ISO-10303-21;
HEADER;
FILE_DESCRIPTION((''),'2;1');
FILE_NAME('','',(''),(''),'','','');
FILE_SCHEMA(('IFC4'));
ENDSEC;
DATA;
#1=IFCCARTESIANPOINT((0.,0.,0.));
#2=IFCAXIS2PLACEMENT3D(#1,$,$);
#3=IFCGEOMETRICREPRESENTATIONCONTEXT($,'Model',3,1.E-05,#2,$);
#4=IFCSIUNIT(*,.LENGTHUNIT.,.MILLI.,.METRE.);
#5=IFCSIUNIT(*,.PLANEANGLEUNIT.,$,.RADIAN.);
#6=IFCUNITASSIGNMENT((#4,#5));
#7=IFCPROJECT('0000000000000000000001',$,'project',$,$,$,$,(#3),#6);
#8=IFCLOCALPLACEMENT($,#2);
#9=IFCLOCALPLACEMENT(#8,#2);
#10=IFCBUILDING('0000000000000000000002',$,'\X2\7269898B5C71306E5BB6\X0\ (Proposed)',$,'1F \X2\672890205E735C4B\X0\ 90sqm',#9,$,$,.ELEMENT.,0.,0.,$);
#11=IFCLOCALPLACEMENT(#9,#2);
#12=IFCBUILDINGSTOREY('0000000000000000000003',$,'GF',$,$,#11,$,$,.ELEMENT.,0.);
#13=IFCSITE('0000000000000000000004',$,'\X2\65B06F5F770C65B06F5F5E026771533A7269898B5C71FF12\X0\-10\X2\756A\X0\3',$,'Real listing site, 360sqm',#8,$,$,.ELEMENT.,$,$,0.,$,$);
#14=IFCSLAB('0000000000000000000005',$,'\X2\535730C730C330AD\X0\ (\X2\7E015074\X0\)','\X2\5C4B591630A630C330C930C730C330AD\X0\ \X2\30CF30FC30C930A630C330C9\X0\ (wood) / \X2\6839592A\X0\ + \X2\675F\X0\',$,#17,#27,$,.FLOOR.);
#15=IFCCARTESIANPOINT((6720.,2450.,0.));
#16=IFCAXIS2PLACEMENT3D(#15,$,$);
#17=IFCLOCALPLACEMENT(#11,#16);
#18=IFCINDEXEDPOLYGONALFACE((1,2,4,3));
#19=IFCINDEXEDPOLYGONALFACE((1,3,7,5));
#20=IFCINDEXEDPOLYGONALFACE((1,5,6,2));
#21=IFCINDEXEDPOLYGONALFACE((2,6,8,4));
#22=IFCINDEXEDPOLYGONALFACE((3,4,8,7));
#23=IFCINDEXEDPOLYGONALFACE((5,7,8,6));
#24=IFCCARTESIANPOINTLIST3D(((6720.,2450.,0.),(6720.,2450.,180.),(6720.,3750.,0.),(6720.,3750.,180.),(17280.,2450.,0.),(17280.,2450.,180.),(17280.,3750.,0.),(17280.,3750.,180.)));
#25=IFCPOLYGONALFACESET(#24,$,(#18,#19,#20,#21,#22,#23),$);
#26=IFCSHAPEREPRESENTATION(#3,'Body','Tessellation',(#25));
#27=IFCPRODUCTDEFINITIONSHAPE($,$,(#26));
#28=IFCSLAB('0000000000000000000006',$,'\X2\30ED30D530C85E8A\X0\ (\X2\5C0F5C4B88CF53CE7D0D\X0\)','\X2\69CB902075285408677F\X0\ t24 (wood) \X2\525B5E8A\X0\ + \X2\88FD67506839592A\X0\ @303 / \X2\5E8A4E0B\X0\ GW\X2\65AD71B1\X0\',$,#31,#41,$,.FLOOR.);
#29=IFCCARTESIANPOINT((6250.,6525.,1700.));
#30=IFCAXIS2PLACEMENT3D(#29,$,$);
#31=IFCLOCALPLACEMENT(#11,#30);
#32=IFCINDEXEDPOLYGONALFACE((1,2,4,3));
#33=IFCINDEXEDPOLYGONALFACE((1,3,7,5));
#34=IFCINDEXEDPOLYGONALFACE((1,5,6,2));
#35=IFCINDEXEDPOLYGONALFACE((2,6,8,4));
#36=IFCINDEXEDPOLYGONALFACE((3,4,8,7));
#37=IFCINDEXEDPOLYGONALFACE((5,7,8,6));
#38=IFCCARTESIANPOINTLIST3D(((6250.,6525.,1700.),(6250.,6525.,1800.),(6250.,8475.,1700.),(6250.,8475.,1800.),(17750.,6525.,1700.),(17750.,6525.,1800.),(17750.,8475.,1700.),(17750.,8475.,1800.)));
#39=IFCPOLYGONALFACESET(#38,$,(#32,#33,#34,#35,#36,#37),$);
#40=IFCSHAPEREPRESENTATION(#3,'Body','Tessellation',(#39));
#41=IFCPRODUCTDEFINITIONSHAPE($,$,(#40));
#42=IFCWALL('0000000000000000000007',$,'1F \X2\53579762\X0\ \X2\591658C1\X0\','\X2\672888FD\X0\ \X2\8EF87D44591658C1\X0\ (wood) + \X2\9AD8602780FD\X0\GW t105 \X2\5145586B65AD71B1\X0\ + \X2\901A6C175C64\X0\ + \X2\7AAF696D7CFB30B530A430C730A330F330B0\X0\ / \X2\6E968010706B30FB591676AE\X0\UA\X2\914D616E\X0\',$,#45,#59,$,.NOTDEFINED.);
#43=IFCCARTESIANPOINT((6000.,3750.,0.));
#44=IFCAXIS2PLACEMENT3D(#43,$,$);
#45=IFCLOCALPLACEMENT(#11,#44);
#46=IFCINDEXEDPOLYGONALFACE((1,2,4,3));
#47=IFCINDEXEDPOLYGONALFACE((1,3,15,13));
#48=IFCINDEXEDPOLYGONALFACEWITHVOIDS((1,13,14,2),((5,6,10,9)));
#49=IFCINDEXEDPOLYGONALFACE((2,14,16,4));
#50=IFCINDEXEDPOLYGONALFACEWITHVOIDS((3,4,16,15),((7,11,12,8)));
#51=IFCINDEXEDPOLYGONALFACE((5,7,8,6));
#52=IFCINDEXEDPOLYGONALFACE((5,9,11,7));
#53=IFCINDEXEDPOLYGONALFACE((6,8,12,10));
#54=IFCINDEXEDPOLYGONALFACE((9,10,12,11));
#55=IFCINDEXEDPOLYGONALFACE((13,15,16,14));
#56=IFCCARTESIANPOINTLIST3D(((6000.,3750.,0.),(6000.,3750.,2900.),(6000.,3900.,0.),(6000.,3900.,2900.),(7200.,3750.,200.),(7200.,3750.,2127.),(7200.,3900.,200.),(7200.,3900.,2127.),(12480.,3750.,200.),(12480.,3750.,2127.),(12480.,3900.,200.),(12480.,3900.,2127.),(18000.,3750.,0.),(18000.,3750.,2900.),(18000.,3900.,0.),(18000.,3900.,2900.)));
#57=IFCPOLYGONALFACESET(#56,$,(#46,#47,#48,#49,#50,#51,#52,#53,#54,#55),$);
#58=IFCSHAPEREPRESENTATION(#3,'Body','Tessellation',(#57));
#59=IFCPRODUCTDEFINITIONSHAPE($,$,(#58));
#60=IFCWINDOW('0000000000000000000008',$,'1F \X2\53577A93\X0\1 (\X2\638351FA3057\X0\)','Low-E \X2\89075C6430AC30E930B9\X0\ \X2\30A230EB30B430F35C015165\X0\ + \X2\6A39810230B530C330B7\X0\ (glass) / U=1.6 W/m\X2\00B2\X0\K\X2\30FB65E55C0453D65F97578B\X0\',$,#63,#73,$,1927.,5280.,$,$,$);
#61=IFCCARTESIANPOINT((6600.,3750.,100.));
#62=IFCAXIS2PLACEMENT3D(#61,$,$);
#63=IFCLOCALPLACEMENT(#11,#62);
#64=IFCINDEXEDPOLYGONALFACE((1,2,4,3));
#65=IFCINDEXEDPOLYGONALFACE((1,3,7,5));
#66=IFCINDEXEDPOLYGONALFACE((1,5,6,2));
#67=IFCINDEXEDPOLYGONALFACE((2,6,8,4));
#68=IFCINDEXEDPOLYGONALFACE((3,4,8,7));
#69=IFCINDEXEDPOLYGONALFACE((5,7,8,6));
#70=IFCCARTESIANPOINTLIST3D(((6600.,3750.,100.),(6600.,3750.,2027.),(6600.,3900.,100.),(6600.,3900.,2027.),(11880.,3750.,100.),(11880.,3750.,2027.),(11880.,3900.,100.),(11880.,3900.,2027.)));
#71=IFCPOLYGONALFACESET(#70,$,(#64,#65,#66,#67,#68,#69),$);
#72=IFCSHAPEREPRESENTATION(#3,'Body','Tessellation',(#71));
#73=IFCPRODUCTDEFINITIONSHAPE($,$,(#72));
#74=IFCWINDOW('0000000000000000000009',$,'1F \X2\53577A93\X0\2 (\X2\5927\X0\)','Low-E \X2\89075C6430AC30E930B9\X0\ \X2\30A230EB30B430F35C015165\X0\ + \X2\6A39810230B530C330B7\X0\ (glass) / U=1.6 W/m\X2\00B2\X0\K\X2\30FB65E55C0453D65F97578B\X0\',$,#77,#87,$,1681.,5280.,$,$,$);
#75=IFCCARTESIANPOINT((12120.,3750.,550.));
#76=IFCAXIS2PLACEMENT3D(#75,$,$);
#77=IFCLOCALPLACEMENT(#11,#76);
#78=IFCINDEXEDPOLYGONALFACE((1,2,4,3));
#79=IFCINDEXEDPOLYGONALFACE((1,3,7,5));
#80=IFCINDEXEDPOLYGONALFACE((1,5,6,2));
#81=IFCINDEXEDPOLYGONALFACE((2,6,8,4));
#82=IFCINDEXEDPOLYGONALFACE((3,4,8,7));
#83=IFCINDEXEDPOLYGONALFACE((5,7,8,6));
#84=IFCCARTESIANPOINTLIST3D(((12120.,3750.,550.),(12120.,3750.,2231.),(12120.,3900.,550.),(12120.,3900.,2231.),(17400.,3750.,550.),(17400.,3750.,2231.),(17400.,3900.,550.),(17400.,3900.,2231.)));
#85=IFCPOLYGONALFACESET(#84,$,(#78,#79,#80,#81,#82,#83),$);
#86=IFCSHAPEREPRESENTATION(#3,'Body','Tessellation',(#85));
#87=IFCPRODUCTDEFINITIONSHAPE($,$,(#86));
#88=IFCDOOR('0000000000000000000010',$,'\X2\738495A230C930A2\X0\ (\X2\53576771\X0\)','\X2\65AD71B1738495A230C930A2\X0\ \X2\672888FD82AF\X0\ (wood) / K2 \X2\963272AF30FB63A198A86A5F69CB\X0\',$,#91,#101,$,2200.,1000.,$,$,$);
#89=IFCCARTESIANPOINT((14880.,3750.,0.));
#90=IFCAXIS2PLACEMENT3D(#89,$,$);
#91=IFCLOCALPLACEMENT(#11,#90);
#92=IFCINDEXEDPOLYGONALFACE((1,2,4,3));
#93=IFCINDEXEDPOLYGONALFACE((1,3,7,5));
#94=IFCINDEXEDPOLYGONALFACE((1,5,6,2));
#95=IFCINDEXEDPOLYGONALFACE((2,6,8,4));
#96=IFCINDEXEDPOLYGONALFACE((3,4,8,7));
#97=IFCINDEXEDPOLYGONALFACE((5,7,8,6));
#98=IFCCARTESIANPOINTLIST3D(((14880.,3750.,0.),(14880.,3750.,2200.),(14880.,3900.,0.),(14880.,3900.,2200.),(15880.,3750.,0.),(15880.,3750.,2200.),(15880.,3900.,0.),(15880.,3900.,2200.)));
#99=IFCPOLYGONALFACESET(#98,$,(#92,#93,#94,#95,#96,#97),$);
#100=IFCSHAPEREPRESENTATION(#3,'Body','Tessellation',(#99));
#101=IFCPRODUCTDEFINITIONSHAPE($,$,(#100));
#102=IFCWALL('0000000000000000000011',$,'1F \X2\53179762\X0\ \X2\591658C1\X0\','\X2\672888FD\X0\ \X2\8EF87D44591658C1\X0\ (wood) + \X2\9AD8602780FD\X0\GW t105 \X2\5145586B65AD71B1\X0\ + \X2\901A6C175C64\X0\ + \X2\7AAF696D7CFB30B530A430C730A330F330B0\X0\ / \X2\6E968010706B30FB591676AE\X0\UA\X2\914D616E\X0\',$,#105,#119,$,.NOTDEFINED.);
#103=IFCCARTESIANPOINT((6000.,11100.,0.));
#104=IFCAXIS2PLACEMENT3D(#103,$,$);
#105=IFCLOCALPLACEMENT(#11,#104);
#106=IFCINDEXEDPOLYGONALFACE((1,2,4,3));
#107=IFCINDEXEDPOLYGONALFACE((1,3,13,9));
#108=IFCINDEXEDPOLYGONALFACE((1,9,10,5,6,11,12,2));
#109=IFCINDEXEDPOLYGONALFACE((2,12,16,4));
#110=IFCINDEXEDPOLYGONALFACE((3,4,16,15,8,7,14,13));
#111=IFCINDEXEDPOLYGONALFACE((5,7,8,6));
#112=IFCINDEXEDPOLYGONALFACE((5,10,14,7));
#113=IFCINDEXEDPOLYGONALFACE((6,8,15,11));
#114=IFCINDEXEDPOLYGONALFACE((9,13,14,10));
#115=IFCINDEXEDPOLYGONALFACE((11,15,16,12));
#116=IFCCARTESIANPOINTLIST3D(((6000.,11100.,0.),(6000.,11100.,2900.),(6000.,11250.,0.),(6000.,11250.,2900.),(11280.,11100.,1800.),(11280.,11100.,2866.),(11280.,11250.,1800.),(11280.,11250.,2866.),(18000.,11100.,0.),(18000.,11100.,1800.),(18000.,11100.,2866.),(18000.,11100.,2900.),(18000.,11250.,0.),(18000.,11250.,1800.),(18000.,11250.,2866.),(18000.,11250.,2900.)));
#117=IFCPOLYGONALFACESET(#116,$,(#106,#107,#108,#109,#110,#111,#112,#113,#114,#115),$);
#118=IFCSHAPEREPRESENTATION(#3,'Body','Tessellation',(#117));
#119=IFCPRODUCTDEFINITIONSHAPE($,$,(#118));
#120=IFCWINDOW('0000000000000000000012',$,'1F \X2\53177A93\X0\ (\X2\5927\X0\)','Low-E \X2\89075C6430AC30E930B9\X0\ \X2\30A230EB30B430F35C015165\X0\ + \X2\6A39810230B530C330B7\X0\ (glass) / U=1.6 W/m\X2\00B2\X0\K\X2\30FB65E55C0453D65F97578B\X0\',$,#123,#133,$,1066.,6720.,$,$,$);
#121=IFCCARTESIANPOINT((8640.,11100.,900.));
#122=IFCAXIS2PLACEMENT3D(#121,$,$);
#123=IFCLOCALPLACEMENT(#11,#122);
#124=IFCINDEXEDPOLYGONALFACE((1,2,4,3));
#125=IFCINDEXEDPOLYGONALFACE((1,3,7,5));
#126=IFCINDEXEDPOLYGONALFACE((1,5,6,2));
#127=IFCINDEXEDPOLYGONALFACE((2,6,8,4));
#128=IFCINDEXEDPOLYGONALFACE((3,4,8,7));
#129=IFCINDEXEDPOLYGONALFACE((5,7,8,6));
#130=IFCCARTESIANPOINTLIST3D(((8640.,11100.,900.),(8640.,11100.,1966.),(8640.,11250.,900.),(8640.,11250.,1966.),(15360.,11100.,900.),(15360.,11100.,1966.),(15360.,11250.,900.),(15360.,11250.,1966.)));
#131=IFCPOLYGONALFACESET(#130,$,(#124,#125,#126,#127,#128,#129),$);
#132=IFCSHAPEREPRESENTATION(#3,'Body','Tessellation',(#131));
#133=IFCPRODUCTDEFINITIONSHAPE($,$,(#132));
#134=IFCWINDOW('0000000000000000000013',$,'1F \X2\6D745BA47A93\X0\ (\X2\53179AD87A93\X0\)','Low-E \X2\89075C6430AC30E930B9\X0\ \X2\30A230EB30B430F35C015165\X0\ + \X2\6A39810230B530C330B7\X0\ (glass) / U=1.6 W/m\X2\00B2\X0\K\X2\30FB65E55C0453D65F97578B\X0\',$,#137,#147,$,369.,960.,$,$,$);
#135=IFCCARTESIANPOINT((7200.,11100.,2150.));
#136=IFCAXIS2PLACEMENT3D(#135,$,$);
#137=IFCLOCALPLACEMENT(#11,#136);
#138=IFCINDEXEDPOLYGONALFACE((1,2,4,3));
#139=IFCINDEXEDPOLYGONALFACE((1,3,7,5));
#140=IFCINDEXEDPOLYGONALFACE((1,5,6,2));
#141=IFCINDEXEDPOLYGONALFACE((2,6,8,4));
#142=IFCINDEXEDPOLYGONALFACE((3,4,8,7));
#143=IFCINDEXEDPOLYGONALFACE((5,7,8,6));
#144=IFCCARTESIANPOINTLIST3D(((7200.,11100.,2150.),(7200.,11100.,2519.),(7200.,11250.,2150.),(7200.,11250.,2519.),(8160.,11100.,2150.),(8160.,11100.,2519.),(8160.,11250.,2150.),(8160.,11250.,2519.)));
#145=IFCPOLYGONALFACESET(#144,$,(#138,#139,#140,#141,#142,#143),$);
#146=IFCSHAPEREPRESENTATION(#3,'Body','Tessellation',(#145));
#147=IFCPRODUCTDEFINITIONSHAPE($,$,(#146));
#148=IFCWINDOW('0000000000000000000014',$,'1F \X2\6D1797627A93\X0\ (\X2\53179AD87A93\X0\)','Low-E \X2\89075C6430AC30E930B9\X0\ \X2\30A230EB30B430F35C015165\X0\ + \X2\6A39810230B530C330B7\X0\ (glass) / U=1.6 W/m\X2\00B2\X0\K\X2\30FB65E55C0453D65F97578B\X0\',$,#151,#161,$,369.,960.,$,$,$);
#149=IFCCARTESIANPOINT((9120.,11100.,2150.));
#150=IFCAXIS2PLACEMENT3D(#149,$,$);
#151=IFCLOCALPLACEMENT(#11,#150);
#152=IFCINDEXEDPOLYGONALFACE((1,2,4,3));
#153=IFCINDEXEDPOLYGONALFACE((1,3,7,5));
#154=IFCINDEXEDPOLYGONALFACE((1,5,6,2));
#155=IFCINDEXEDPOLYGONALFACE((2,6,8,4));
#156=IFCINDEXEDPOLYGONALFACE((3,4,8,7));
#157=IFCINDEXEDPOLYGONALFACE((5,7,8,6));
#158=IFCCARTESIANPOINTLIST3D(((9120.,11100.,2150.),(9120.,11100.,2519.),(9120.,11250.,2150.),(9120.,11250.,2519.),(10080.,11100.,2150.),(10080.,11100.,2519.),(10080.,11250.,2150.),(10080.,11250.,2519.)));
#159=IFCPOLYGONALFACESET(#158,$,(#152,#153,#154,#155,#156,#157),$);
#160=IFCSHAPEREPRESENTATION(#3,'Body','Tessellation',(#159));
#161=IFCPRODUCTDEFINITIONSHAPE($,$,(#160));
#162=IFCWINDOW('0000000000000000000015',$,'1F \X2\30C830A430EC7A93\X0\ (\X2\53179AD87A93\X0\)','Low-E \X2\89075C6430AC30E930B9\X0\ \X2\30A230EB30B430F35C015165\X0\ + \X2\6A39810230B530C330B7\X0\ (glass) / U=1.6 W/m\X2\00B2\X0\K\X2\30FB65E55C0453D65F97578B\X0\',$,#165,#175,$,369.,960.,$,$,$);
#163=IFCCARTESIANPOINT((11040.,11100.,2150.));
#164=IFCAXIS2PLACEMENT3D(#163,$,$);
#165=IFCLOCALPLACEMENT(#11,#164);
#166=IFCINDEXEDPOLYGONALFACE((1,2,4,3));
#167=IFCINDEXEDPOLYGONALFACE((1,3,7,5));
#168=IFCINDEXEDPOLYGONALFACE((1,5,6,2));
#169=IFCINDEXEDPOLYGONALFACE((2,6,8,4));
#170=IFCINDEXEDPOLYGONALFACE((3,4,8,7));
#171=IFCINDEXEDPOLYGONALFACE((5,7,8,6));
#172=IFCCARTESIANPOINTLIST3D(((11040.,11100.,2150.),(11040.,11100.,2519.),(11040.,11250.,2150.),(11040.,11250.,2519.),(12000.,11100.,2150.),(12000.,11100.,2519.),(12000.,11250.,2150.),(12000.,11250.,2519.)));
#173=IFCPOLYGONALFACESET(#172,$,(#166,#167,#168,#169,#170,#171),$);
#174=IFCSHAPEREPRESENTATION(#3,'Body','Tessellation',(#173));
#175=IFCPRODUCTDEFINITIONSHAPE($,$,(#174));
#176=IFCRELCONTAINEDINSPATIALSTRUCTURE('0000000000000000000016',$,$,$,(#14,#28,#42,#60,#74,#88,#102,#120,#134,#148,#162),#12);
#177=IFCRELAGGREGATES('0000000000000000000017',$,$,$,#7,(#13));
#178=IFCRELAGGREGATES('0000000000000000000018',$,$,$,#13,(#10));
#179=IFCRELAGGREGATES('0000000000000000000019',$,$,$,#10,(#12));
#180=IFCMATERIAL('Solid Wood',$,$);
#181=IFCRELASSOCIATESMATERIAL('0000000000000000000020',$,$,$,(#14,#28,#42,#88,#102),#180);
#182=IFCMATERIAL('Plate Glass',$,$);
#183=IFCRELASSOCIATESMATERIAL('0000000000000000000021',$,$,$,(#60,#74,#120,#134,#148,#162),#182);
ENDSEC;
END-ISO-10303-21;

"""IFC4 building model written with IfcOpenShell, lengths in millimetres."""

from ifc_helpers import new_model, si_unit, frame, frame_2d, origin, place, context, project, spatial, rectangle, extrude, material, element, fill, save


model = new_model("IFC4")

# Units and contexts
model_context = context("Model", 3, precision=1e-05, world=origin())
ifc_project = project(units=[si_unit("LENGTHUNIT", "METRE", prefix="MILLI"), si_unit("PLANEANGLEUNIT", "RADIAN")], contexts=[model_context])

# Site, building, storey
site_placement = place(None, origin())
site = spatial("IfcSite", under=ifc_project, at=site_placement, Name="新潟県新潟市東区物見山２-10番3", ObjectType="Real listing site, 360sqm", CompositionType="ELEMENT", RefElevation=0.0)
building_placement = place(site_placement, origin())
building = spatial("IfcBuilding", under=site, at=building_placement, Name="物見山の家 (Proposed)", ObjectType="1F 木造平屋 90sqm", CompositionType="ELEMENT", ElevationOfRefHeight=0.0, ElevationOfTerrain=0.0)
storey_placement = place(building_placement, origin())
storey = spatial("IfcBuildingStorey", under=building, at=storey_placement, Name="GF", CompositionType="ELEMENT", Elevation=0.0)

# Slabs
ifc_material_1 = material(Name="Solid Wood")
slab_1_placement = place(storey_placement, frame((6720.0, 2450.0, 0.0)))
element("IfcSlab", 1, at=slab_1_placement, inside=storey, material=ifc_material_1, Name="南デッキ (縁側)", Description="屋外ウッドデッキ ハードウッド (wood) / 根太 + 束", PredefinedType="FLOOR", context=model_context, shape_type="SweptSolid", body=[
    extrude(rectangle(XDim=10560.0, YDim=1300.0, at=frame_2d((5280.0, 650.0))), frame((6720.0, 2450.0, 0.0)), (0.0, 0.0, 1.0), 180.0),
])
slab_2_placement = place(storey_placement, frame((6250.0, 6525.0, 1700.0)))
element("IfcSlab", 2, at=slab_2_placement, inside=storey, material=ifc_material_1, Name="ロフト床 (小屋裏収納)", Description="構造用合板 t24 (wood) 剛床 + 製材根太 @303 / 床下 GW断熱", PredefinedType="FLOOR", context=model_context, shape_type="SweptSolid", body=[
    extrude(rectangle(XDim=11500.0, YDim=1950.0, at=frame_2d((5750.0, 975.0))), frame((6250.0, 6525.0, 1700.0)), (0.0, 0.0, 1.0), 100.0),
])

# Wall, openings, windows, door
wall_1_placement = place(storey_placement, frame((6000.0, 3750.0, 0.0)))
wall_1 = element("IfcWall", 3, at=wall_1_placement, inside=storey, material=ifc_material_1, Name="1F 南面 外壁", Description="木製 軸組外壁 (wood) + 高性能GW t105 充填断熱 + 通気層 + 窯業系サイディング / 準耐火・外皮UA配慮", PredefinedType="NOTDEFINED", context=model_context, shape_type="SweptSolid", body=[
    extrude(rectangle(XDim=12000.0, YDim=150.0, at=frame_2d((6000.0, 75.0))), frame((6000.0, 3750.0, 0.0)), (0.0, 0.0, 1.0), 2900.0),
])
opening_1_placement = place(storey_placement, frame((6600.0, 3750.0, 100.0)))
opening_1 = element("IfcOpeningElement", 4, at=opening_1_placement, cuts=wall_1, PredefinedType="NOTDEFINED", context=model_context, shape_type="SweptSolid", body=[
    extrude(rectangle(XDim=5280.0, YDim=150.0, at=frame_2d((2640.0, 75.0))), frame((6600.0, 3750.0, 100.0)), (0.0, 0.0, 1.0), 1927.0),
])
opening_2_placement = place(storey_placement, frame((12120.0, 3750.0, 550.0)))
opening_2 = element("IfcOpeningElement", 5, at=opening_2_placement, cuts=wall_1, PredefinedType="NOTDEFINED", context=model_context, shape_type="SweptSolid", body=[
    extrude(rectangle(XDim=5280.0, YDim=150.0, at=frame_2d((2640.0, 75.0))), frame((12120.0, 3750.0, 550.0)), (0.0, 0.0, 1.0), 1681.0),
])
opening_3_placement = place(storey_placement, frame((14880.0, 3750.0, 0.0)))
opening_3 = element("IfcOpeningElement", 6, at=opening_3_placement, cuts=wall_1, PredefinedType="NOTDEFINED", context=model_context, shape_type="SweptSolid", body=[
    extrude(rectangle(XDim=1000.0, YDim=150.0, at=frame_2d((500.0, 75.0))), frame((14880.0, 3750.0, 0.0)), (0.0, 0.0, 1.0), 2200.0),
])
ifc_material_2 = material(Name="Plate Glass")
window_1_placement = place(storey_placement, frame((6600.0, 3750.0, 100.0)))
window_1 = element("IfcWindow", 7, at=window_1_placement, inside=storey, material=ifc_material_2, Name="1F 南窓1 (掃出し)", Description="Low-E 複層ガラス アルゴン封入 + 樹脂サッシ (glass) / U=1.6 W/m²K・日射取得型", OverallHeight=1927.0, OverallWidth=5280.0, context=model_context, shape_type="SweptSolid", body=[
    extrude(rectangle(XDim=5280.0, YDim=150.0, at=frame_2d((2640.0, 75.0))), frame((6600.0, 3750.0, 100.0)), (0.0, 0.0, 1.0), 1927.0),
])
fill(opening_1, window_1)
window_2_placement = place(storey_placement, frame((12120.0, 3750.0, 550.0)))
window_2 = element("IfcWindow", 8, at=window_2_placement, inside=storey, material=ifc_material_2, Name="1F 南窓2 (大)", Description="Low-E 複層ガラス アルゴン封入 + 樹脂サッシ (glass) / U=1.6 W/m²K・日射取得型", OverallHeight=1681.0, OverallWidth=5280.0, context=model_context, shape_type="SweptSolid", body=[
    extrude(rectangle(XDim=5280.0, YDim=150.0, at=frame_2d((2640.0, 75.0))), frame((12120.0, 3750.0, 550.0)), (0.0, 0.0, 1.0), 1681.0),
])
fill(opening_2, window_2)
door_1_placement = place(storey_placement, frame((14880.0, 3750.0, 0.0)))
door_1 = element("IfcDoor", 9, at=door_1_placement, inside=storey, material=ifc_material_1, Name="玄関ドア (南東)", Description="断熱玄関ドア 木製芯 (wood) / K2 防犯・採風機構", OverallHeight=2200.0, OverallWidth=1000.0, context=model_context, shape_type="SweptSolid", body=[
    extrude(rectangle(XDim=1000.0, YDim=150.0, at=frame_2d((500.0, 75.0))), frame((14880.0, 3750.0, 0.0)), (0.0, 0.0, 1.0), 2200.0),
])
fill(opening_3, door_1)

# Wall, openings, windows
wall_2_placement = place(storey_placement, frame((6000.0, 11100.0, 0.0)))
wall_2 = element("IfcWall", 10, at=wall_2_placement, inside=storey, material=ifc_material_1, Name="1F 北面 外壁", Description="木製 軸組外壁 (wood) + 高性能GW t105 充填断熱 + 通気層 + 窯業系サイディング / 準耐火・外皮UA配慮", PredefinedType="NOTDEFINED", context=model_context, shape_type="SweptSolid", body=[
    extrude(rectangle(XDim=12000.0, YDim=150.0, at=frame_2d((6000.0, 75.0))), frame((6000.0, 11100.0, 0.0)), (0.0, 0.0, 1.0), 2900.0),
])
opening_4_placement = place(storey_placement, frame((8640.0, 11100.0, 900.0)))
opening_4 = element("IfcOpeningElement", 11, at=opening_4_placement, cuts=wall_2, PredefinedType="NOTDEFINED", context=model_context, shape_type="SweptSolid", body=[
    extrude(rectangle(XDim=6720.0, YDim=150.0, at=frame_2d((3360.0, 75.0))), frame((8640.0, 11100.0, 900.0)), (0.0, 0.0, 1.0), 1066.0),
])
opening_5_placement = place(storey_placement, frame((7200.0, 11100.0, 2150.0)))
opening_5 = element("IfcOpeningElement", 12, at=opening_5_placement, cuts=wall_2, PredefinedType="NOTDEFINED", context=model_context, shape_type="SweptSolid", body=[
    extrude(rectangle(XDim=960.0, YDim=150.0, at=frame_2d((480.0, 75.0))), frame((7200.0, 11100.0, 2150.0)), (0.0, 0.0, 1.0), 369.0),
])
opening_6_placement = place(storey_placement, frame((9120.0, 11100.0, 2150.0)))
opening_6 = element("IfcOpeningElement", 13, at=opening_6_placement, cuts=wall_2, PredefinedType="NOTDEFINED", context=model_context, shape_type="SweptSolid", body=[
    extrude(rectangle(XDim=960.0, YDim=150.0, at=frame_2d((480.0, 75.0))), frame((9120.0, 11100.0, 2150.0)), (0.0, 0.0, 1.0), 369.0),
])
opening_7_placement = place(storey_placement, frame((11040.0, 11100.0, 2150.0)))
opening_7 = element("IfcOpeningElement", 14, at=opening_7_placement, cuts=wall_2, PredefinedType="NOTDEFINED", context=model_context, shape_type="SweptSolid", body=[
    extrude(rectangle(XDim=960.0, YDim=150.0, at=frame_2d((480.0, 75.0))), frame((11040.0, 11100.0, 2150.0)), (0.0, 0.0, 1.0), 369.0),
])
window_3_placement = place(storey_placement, frame((8640.0, 11100.0, 900.0)))
window_3 = element("IfcWindow", 15, at=window_3_placement, inside=storey, material=ifc_material_2, Name="1F 北窓 (大)", Description="Low-E 複層ガラス アルゴン封入 + 樹脂サッシ (glass) / U=1.6 W/m²K・日射取得型", OverallHeight=1066.0, OverallWidth=6720.0, context=model_context, shape_type="SweptSolid", body=[
    extrude(rectangle(XDim=6720.0, YDim=150.0, at=frame_2d((3360.0, 75.0))), frame((8640.0, 11100.0, 900.0)), (0.0, 0.0, 1.0), 1066.0),
])
fill(opening_4, window_3)
window_4_placement = place(storey_placement, frame((7200.0, 11100.0, 2150.0)))
window_4 = element("IfcWindow", 16, at=window_4_placement, inside=storey, material=ifc_material_2, Name="1F 浴室窓 (北高窓)", Description="Low-E 複層ガラス アルゴン封入 + 樹脂サッシ (glass) / U=1.6 W/m²K・日射取得型", OverallHeight=369.0, OverallWidth=960.0, context=model_context, shape_type="SweptSolid", body=[
    extrude(rectangle(XDim=960.0, YDim=150.0, at=frame_2d((480.0, 75.0))), frame((7200.0, 11100.0, 2150.0)), (0.0, 0.0, 1.0), 369.0),
])
fill(opening_5, window_4)
window_5_placement = place(storey_placement, frame((9120.0, 11100.0, 2150.0)))
window_5 = element("IfcWindow", 17, at=window_5_placement, inside=storey, material=ifc_material_2, Name="1F 洗面窓 (北高窓)", Description="Low-E 複層ガラス アルゴン封入 + 樹脂サッシ (glass) / U=1.6 W/m²K・日射取得型", OverallHeight=369.0, OverallWidth=960.0, context=model_context, shape_type="SweptSolid", body=[
    extrude(rectangle(XDim=960.0, YDim=150.0, at=frame_2d((480.0, 75.0))), frame((9120.0, 11100.0, 2150.0)), (0.0, 0.0, 1.0), 369.0),
])
fill(opening_6, window_5)
window_6_placement = place(storey_placement, frame((11040.0, 11100.0, 2150.0)))
window_6 = element("IfcWindow", 18, at=window_6_placement, inside=storey, material=ifc_material_2, Name="1F トイレ窓 (北高窓)", Description="Low-E 複層ガラス アルゴン封入 + 樹脂サッシ (glass) / U=1.6 W/m²K・日射取得型", OverallHeight=369.0, OverallWidth=960.0, context=model_context, shape_type="SweptSolid", body=[
    extrude(rectangle(XDim=960.0, YDim=150.0, at=frame_2d((480.0, 75.0))), frame((11040.0, 11100.0, 2150.0)), (0.0, 0.0, 1.0), 369.0),
])
fill(opening_7, window_6)

save(model, "model.ifc")
